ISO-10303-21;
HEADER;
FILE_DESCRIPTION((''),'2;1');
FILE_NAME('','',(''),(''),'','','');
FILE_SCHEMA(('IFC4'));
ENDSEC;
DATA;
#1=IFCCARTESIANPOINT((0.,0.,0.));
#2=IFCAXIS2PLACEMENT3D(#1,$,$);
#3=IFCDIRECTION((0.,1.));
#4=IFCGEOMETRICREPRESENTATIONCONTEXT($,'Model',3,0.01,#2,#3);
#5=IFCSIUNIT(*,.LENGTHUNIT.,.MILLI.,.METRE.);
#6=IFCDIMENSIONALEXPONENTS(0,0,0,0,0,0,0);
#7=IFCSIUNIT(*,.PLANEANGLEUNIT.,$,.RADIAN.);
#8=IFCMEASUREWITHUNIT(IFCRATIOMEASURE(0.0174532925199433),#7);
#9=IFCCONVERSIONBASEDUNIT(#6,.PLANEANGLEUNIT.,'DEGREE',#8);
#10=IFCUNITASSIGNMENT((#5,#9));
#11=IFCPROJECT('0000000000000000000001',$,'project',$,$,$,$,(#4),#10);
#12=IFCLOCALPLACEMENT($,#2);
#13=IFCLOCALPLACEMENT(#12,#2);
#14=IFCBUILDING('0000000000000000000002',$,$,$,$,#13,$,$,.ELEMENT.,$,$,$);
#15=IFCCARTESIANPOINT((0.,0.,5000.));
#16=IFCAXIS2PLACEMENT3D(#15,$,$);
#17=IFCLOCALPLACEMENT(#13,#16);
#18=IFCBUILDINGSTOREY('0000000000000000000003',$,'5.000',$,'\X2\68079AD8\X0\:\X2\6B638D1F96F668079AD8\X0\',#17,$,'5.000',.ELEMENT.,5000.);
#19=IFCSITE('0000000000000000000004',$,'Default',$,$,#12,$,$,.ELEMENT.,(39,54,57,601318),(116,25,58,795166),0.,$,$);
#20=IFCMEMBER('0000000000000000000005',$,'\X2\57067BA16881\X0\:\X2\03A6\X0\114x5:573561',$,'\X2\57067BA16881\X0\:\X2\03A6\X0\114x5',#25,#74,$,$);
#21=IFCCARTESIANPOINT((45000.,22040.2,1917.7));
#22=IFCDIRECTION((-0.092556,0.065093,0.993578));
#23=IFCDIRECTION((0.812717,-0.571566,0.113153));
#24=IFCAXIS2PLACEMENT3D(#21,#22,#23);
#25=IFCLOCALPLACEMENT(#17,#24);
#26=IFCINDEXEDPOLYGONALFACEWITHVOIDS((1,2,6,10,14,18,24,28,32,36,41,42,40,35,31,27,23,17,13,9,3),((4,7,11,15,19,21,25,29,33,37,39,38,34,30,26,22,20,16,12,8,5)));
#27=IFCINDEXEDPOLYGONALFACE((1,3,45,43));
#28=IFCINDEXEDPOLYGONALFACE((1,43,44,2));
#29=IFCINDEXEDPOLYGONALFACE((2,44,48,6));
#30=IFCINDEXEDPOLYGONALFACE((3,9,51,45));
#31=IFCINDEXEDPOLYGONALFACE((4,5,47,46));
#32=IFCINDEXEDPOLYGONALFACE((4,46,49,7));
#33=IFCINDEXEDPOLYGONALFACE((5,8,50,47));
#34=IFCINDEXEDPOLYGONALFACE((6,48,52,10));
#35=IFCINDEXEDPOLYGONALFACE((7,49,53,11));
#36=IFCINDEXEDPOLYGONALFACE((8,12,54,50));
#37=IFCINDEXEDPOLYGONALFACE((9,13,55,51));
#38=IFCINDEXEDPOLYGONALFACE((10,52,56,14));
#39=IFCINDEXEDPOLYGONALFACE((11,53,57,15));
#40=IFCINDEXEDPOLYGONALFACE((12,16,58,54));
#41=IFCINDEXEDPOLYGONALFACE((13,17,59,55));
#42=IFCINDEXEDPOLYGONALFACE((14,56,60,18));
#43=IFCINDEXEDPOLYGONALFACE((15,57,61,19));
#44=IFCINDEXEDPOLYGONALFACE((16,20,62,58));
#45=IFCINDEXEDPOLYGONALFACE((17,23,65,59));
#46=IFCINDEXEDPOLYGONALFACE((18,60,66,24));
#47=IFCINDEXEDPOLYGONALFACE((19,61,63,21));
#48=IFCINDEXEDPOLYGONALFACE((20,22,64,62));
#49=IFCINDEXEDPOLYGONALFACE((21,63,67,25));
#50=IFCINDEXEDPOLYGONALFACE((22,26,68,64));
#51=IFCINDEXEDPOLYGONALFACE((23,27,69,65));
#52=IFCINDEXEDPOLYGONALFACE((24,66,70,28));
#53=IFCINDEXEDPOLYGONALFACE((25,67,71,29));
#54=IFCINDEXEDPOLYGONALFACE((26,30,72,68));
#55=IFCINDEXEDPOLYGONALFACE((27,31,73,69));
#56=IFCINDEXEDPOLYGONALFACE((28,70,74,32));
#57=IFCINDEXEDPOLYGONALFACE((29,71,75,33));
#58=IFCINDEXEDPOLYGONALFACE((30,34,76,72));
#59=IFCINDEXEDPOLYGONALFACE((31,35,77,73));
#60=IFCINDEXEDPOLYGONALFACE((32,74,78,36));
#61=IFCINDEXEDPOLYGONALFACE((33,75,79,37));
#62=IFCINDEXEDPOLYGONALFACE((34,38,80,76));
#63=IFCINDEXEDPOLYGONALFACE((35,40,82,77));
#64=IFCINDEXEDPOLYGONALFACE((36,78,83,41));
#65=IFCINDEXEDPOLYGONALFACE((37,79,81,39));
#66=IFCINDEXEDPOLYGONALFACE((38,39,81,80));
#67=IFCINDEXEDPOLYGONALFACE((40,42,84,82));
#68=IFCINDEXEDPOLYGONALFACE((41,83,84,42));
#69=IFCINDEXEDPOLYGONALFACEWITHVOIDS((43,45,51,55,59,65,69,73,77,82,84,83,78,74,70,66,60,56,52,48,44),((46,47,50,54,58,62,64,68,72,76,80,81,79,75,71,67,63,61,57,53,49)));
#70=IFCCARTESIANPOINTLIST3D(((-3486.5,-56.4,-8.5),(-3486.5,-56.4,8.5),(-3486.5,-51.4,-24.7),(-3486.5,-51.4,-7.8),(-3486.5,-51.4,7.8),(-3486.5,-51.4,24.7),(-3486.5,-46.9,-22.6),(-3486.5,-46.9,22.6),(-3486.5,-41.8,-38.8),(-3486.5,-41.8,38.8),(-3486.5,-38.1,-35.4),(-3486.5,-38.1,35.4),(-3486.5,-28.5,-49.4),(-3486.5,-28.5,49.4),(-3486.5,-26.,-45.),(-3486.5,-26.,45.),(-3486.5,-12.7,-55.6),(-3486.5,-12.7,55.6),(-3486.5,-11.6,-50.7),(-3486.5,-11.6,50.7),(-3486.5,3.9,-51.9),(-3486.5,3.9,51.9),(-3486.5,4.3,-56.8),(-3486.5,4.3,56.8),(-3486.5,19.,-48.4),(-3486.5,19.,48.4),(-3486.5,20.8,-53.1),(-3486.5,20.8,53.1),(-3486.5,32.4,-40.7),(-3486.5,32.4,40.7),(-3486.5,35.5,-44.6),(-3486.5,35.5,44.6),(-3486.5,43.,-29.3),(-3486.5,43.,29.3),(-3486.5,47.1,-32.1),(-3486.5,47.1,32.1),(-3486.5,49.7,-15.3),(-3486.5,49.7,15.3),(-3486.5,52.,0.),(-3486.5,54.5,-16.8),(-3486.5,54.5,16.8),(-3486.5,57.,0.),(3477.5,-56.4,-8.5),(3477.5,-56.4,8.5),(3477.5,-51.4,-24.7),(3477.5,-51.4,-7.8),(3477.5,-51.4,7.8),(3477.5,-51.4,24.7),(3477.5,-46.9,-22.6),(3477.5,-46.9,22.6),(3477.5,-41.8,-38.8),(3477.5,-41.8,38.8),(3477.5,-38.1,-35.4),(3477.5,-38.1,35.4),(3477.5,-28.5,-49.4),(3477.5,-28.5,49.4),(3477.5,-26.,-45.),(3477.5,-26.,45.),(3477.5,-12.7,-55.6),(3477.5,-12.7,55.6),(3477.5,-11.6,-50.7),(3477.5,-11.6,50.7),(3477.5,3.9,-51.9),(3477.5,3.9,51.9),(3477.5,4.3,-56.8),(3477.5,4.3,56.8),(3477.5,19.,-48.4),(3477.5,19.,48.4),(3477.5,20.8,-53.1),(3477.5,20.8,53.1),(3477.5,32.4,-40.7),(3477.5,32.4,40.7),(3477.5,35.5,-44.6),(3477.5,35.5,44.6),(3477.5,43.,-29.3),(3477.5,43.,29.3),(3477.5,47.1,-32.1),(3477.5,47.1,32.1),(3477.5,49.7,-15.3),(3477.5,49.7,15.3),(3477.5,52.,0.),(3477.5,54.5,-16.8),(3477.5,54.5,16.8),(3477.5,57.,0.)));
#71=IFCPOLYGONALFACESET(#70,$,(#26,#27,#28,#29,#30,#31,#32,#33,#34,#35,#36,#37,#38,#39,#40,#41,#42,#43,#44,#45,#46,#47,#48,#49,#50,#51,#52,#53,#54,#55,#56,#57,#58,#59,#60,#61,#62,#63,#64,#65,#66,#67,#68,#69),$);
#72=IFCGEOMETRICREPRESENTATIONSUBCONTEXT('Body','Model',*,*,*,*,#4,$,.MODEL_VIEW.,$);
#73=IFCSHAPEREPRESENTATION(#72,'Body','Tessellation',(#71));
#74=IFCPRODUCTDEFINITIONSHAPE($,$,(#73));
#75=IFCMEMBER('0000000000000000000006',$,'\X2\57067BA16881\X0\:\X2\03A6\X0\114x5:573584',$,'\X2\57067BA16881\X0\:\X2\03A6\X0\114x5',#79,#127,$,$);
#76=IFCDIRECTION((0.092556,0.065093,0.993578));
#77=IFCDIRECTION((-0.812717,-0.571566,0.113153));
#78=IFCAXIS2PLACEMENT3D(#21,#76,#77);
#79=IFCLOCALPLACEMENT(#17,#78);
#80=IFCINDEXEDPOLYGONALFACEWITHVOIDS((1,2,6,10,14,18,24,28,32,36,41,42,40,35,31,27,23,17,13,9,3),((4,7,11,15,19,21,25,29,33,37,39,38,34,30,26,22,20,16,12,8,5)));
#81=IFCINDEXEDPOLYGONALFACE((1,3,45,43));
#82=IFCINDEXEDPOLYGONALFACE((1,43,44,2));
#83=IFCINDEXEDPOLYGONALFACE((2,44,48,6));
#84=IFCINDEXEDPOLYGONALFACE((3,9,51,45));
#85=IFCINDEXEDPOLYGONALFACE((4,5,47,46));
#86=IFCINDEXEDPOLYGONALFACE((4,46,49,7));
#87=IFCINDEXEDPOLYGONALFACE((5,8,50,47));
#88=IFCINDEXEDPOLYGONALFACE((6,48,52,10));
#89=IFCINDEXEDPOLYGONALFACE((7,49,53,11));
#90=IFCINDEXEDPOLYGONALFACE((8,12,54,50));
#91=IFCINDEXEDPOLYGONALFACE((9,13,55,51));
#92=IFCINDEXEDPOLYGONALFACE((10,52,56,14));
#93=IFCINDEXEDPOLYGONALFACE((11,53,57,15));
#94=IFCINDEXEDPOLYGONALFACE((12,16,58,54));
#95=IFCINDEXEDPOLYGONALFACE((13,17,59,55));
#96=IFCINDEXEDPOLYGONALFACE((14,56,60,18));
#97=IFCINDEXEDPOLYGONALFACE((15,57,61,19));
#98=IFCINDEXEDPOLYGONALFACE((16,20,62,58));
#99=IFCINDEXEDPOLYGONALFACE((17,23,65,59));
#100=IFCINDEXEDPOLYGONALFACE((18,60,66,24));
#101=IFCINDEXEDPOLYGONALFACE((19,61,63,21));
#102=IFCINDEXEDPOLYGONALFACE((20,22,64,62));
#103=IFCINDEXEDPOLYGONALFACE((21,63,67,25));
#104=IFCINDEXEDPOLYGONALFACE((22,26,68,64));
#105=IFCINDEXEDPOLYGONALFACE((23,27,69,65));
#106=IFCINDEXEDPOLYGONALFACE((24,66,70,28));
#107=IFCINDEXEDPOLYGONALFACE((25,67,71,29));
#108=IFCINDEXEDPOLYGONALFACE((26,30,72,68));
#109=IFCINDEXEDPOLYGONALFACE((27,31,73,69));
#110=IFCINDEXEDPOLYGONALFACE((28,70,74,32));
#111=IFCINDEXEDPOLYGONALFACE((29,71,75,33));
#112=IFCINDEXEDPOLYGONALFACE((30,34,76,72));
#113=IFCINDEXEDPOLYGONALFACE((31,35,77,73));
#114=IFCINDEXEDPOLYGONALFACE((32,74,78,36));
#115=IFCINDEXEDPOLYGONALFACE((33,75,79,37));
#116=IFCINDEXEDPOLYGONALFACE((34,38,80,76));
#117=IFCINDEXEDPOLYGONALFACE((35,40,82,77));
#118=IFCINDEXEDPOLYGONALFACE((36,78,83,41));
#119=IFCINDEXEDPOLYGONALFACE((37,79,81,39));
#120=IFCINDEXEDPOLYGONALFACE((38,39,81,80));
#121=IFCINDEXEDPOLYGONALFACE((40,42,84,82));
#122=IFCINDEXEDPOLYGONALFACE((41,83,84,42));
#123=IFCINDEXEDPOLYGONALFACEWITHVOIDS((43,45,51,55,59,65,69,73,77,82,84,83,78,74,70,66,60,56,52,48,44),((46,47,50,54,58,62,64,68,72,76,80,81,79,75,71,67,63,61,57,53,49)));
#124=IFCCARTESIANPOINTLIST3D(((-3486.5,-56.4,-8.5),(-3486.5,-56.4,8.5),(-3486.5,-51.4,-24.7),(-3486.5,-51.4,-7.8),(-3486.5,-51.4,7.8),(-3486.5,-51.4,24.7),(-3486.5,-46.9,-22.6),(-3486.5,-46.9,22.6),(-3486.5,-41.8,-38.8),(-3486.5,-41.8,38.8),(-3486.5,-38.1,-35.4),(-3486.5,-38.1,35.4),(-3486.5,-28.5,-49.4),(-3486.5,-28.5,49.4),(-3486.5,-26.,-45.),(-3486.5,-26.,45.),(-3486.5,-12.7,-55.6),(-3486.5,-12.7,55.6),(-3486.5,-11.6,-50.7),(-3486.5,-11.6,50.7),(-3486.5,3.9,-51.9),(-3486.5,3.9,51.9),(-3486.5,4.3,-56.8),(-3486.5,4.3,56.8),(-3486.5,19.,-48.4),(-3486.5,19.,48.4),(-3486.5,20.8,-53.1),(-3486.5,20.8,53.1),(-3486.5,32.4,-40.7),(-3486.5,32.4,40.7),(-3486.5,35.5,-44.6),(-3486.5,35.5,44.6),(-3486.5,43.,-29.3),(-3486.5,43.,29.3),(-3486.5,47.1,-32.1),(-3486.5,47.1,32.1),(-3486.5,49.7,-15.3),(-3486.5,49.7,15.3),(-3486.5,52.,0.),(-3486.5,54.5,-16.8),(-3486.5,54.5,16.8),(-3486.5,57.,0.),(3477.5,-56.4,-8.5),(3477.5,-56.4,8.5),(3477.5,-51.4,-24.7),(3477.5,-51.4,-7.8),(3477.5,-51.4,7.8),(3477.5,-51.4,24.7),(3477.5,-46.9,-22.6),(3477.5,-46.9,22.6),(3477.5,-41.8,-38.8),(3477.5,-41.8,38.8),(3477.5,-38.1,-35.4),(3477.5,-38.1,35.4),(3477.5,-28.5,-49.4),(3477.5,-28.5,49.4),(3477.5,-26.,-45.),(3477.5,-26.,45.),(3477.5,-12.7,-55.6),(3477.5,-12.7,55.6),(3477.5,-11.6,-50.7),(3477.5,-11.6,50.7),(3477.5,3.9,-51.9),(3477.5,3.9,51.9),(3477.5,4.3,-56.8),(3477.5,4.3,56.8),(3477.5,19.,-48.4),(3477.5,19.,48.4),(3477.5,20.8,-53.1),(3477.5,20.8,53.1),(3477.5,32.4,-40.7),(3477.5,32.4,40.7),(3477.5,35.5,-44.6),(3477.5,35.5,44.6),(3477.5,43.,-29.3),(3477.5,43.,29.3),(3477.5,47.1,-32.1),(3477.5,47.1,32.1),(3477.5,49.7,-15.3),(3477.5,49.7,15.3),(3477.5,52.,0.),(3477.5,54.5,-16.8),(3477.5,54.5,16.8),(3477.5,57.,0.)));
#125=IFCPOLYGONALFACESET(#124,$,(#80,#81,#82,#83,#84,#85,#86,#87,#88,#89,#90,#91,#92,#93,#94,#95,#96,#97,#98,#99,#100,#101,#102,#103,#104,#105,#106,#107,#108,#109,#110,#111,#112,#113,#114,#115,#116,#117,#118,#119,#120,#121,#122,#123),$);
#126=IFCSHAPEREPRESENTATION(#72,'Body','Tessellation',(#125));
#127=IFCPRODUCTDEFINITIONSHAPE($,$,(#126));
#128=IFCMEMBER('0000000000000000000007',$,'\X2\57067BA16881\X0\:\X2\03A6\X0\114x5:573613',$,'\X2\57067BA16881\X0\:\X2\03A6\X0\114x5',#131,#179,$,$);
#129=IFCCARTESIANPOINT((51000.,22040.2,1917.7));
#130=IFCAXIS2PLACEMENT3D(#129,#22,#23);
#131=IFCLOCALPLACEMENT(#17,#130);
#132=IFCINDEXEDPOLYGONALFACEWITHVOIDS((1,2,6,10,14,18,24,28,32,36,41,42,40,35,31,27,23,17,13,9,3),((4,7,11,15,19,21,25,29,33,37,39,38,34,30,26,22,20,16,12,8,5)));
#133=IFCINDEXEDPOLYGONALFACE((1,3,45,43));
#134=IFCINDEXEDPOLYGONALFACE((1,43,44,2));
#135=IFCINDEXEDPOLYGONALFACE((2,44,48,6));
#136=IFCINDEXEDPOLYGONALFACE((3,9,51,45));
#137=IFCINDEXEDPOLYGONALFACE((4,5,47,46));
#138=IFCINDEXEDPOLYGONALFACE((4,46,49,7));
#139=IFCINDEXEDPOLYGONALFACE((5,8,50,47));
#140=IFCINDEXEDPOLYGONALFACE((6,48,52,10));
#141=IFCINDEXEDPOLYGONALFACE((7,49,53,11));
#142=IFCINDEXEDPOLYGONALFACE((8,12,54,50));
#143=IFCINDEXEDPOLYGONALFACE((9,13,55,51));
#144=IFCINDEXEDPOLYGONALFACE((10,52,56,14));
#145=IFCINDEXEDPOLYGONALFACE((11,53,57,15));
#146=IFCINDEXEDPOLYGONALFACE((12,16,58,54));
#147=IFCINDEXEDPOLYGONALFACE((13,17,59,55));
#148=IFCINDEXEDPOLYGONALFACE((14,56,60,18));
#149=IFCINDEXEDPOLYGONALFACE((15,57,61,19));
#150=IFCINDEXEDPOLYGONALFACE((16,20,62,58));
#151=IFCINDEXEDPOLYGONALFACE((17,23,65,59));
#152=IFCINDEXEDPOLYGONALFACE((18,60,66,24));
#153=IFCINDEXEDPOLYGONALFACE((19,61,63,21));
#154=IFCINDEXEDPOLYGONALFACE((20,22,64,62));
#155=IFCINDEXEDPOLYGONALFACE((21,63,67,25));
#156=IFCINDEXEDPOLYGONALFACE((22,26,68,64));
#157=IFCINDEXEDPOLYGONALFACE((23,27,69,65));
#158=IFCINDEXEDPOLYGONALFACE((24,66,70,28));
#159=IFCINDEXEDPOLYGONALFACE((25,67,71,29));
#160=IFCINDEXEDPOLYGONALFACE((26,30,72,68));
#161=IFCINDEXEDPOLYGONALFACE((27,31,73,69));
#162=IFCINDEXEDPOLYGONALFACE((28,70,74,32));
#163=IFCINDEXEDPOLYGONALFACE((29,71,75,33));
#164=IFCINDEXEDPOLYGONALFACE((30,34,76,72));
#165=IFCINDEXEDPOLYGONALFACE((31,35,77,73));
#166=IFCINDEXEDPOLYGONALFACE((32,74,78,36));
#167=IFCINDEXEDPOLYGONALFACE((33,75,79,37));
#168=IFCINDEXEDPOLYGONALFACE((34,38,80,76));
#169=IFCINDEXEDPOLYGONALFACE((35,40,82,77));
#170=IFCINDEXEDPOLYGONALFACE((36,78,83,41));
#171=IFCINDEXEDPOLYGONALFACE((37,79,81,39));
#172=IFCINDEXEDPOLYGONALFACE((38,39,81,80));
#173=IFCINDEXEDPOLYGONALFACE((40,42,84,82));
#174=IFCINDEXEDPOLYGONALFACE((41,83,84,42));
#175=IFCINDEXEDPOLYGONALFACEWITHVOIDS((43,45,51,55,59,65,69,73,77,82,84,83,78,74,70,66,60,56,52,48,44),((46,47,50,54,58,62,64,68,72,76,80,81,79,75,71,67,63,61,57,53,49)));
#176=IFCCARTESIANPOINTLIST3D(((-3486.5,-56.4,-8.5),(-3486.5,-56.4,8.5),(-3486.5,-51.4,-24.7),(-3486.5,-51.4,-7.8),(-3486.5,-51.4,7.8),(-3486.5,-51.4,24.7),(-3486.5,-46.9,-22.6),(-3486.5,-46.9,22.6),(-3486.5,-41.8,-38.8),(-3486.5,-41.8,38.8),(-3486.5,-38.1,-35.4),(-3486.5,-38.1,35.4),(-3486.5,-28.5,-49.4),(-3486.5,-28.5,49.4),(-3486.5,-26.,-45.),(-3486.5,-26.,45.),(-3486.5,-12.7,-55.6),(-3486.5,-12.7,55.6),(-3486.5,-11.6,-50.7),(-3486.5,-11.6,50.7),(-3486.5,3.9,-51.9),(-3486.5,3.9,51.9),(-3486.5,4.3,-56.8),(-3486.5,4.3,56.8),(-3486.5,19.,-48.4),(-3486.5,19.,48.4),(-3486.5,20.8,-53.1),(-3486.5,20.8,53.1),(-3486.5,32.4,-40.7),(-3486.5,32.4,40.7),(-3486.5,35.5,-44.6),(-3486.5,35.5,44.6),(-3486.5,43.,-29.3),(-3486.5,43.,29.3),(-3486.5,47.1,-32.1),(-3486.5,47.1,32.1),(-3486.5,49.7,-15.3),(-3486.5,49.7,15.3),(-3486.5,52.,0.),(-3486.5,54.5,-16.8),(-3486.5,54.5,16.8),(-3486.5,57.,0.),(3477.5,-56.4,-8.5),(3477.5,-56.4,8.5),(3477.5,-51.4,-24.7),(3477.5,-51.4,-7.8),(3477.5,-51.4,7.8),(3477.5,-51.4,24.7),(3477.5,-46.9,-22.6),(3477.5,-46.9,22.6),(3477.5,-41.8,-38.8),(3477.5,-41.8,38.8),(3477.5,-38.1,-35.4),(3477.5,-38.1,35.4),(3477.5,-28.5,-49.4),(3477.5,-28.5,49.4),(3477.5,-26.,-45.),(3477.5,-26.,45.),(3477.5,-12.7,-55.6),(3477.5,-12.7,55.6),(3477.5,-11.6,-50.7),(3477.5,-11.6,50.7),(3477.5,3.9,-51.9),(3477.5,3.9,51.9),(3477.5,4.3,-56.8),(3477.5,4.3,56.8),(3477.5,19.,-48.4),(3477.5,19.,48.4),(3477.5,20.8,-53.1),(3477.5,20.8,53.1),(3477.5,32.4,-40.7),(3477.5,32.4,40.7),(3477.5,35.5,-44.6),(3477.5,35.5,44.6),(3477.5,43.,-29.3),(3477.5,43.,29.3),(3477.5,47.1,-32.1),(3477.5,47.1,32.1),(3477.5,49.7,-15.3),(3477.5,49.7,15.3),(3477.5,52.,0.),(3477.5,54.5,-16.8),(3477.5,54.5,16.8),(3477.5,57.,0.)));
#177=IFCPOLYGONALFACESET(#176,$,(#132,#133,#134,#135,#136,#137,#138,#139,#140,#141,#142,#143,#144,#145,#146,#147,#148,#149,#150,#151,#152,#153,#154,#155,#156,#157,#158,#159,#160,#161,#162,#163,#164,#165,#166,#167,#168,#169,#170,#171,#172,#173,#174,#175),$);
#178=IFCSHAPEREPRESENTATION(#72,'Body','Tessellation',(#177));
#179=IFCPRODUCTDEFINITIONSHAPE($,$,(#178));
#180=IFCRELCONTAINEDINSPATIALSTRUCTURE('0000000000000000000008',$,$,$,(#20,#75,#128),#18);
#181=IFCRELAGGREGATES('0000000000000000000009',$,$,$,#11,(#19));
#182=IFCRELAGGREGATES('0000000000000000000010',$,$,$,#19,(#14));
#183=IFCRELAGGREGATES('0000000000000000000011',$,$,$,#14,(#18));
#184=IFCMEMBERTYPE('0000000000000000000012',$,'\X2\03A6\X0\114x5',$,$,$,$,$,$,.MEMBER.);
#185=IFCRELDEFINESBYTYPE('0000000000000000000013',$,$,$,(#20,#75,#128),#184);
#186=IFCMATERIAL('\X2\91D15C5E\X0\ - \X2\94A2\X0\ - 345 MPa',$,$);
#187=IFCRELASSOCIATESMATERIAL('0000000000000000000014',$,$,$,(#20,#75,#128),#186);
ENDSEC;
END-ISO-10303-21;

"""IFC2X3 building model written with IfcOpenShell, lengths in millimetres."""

from ifc_helpers import new_model, entity, si_unit, converted_unit, direction, frame, frame_2d, origin, place, context, subcontext, project, spatial, hollow_circle, extrude, source, transform, mapped, material, type_object, type_shapes, element, save


model = new_model("IFC2X3")

# Units and contexts
model_context = context("Model", 3, precision=0.01, world=origin(), true_north=direction((0.0, 1.0)))
body_context = subcontext(model_context, "Body", "Model", "MODEL_VIEW")
ifc_project = project(units=[si_unit("LENGTHUNIT", "METRE", prefix="MILLI"), converted_unit("PLANEANGLEUNIT", "DEGREE", entity("IfcRatioMeasure", 0.0174532925199433), si_unit("PLANEANGLEUNIT", "RADIAN"), dimensions=[0, 0, 0, 0, 0, 0, 0])], contexts=[model_context])

# Site, building, storey
site_placement = place(None, origin())
site = spatial("IfcSite", under=ifc_project, at=site_placement, Name="Default", CompositionType="ELEMENT", RefLatitude=(39, 54, 57, 601318), RefLongitude=(116, 25, 58, 795166), RefElevation=0.0)
building_placement = place(site_placement, origin())
building = spatial("IfcBuilding", under=site, at=building_placement, CompositionType="ELEMENT")
storey_placement = place(building_placement, frame((0.0, 0.0, 5000.0)))
storey = spatial("IfcBuildingStorey", under=building, at=storey_placement, Name="5.000", ObjectType="标高:正负零标高", LongName="5.000", CompositionType="ELEMENT", Elevation=5000.0)

# Members
ifc_material_1 = material(Name="金属 - 钢 - 345 MPa")
member_type_1 = type_object("IfcMemberType", Name="Φ114x5", PredefinedType="MEMBER")
shared_shape_1 = source(origin(), body_context, "Body", "SweptSolid", [
    extrude(hollow_circle(Radius=57.0, WallThickness=5.0, at=frame_2d((0.0, 0.0), x_axis=(1.0, 0.0))), frame((-3486.5, 0.0, 0.0), z_axis=(1.0, 0.0, 0.0), x_axis=(0.0, 1.0, 0.0)), (0.0, 0.0, 1.0), 6964.0),
])
type_shapes(member_type_1, [shared_shape_1])
for number, where, z_axis, x_axis, name in (
    (1, (45000.0, 22040.2, 1917.7), (-0.092556, 0.065093, 0.993578), (0.812717, -0.571566, 0.113153), "圆管梁:Φ114x5:573561"),
    (2, (45000.0, 22040.2, 1917.7), (0.092556, 0.065093, 0.993578), (-0.812717, -0.571566, 0.113153), "圆管梁:Φ114x5:573584"),
    (3, (51000.0, 22040.2, 1917.7), (-0.092556, 0.065093, 0.993578), (0.812717, -0.571566, 0.113153), "圆管梁:Φ114x5:573613"),
):
    element("IfcMember", number, at=place(storey_placement, frame(where, z_axis=z_axis, x_axis=x_axis)), inside=storey, type_object=member_type_1, material=ifc_material_1, Name=name, ObjectType="圆管梁:Φ114x5", context=body_context, shape_type="MappedRepresentation", body=[
        mapped(shared_shape_1, transform((0.0, 0.0, 0.0), scale=1.0)),
    ])

save(model, "model.ifc")
